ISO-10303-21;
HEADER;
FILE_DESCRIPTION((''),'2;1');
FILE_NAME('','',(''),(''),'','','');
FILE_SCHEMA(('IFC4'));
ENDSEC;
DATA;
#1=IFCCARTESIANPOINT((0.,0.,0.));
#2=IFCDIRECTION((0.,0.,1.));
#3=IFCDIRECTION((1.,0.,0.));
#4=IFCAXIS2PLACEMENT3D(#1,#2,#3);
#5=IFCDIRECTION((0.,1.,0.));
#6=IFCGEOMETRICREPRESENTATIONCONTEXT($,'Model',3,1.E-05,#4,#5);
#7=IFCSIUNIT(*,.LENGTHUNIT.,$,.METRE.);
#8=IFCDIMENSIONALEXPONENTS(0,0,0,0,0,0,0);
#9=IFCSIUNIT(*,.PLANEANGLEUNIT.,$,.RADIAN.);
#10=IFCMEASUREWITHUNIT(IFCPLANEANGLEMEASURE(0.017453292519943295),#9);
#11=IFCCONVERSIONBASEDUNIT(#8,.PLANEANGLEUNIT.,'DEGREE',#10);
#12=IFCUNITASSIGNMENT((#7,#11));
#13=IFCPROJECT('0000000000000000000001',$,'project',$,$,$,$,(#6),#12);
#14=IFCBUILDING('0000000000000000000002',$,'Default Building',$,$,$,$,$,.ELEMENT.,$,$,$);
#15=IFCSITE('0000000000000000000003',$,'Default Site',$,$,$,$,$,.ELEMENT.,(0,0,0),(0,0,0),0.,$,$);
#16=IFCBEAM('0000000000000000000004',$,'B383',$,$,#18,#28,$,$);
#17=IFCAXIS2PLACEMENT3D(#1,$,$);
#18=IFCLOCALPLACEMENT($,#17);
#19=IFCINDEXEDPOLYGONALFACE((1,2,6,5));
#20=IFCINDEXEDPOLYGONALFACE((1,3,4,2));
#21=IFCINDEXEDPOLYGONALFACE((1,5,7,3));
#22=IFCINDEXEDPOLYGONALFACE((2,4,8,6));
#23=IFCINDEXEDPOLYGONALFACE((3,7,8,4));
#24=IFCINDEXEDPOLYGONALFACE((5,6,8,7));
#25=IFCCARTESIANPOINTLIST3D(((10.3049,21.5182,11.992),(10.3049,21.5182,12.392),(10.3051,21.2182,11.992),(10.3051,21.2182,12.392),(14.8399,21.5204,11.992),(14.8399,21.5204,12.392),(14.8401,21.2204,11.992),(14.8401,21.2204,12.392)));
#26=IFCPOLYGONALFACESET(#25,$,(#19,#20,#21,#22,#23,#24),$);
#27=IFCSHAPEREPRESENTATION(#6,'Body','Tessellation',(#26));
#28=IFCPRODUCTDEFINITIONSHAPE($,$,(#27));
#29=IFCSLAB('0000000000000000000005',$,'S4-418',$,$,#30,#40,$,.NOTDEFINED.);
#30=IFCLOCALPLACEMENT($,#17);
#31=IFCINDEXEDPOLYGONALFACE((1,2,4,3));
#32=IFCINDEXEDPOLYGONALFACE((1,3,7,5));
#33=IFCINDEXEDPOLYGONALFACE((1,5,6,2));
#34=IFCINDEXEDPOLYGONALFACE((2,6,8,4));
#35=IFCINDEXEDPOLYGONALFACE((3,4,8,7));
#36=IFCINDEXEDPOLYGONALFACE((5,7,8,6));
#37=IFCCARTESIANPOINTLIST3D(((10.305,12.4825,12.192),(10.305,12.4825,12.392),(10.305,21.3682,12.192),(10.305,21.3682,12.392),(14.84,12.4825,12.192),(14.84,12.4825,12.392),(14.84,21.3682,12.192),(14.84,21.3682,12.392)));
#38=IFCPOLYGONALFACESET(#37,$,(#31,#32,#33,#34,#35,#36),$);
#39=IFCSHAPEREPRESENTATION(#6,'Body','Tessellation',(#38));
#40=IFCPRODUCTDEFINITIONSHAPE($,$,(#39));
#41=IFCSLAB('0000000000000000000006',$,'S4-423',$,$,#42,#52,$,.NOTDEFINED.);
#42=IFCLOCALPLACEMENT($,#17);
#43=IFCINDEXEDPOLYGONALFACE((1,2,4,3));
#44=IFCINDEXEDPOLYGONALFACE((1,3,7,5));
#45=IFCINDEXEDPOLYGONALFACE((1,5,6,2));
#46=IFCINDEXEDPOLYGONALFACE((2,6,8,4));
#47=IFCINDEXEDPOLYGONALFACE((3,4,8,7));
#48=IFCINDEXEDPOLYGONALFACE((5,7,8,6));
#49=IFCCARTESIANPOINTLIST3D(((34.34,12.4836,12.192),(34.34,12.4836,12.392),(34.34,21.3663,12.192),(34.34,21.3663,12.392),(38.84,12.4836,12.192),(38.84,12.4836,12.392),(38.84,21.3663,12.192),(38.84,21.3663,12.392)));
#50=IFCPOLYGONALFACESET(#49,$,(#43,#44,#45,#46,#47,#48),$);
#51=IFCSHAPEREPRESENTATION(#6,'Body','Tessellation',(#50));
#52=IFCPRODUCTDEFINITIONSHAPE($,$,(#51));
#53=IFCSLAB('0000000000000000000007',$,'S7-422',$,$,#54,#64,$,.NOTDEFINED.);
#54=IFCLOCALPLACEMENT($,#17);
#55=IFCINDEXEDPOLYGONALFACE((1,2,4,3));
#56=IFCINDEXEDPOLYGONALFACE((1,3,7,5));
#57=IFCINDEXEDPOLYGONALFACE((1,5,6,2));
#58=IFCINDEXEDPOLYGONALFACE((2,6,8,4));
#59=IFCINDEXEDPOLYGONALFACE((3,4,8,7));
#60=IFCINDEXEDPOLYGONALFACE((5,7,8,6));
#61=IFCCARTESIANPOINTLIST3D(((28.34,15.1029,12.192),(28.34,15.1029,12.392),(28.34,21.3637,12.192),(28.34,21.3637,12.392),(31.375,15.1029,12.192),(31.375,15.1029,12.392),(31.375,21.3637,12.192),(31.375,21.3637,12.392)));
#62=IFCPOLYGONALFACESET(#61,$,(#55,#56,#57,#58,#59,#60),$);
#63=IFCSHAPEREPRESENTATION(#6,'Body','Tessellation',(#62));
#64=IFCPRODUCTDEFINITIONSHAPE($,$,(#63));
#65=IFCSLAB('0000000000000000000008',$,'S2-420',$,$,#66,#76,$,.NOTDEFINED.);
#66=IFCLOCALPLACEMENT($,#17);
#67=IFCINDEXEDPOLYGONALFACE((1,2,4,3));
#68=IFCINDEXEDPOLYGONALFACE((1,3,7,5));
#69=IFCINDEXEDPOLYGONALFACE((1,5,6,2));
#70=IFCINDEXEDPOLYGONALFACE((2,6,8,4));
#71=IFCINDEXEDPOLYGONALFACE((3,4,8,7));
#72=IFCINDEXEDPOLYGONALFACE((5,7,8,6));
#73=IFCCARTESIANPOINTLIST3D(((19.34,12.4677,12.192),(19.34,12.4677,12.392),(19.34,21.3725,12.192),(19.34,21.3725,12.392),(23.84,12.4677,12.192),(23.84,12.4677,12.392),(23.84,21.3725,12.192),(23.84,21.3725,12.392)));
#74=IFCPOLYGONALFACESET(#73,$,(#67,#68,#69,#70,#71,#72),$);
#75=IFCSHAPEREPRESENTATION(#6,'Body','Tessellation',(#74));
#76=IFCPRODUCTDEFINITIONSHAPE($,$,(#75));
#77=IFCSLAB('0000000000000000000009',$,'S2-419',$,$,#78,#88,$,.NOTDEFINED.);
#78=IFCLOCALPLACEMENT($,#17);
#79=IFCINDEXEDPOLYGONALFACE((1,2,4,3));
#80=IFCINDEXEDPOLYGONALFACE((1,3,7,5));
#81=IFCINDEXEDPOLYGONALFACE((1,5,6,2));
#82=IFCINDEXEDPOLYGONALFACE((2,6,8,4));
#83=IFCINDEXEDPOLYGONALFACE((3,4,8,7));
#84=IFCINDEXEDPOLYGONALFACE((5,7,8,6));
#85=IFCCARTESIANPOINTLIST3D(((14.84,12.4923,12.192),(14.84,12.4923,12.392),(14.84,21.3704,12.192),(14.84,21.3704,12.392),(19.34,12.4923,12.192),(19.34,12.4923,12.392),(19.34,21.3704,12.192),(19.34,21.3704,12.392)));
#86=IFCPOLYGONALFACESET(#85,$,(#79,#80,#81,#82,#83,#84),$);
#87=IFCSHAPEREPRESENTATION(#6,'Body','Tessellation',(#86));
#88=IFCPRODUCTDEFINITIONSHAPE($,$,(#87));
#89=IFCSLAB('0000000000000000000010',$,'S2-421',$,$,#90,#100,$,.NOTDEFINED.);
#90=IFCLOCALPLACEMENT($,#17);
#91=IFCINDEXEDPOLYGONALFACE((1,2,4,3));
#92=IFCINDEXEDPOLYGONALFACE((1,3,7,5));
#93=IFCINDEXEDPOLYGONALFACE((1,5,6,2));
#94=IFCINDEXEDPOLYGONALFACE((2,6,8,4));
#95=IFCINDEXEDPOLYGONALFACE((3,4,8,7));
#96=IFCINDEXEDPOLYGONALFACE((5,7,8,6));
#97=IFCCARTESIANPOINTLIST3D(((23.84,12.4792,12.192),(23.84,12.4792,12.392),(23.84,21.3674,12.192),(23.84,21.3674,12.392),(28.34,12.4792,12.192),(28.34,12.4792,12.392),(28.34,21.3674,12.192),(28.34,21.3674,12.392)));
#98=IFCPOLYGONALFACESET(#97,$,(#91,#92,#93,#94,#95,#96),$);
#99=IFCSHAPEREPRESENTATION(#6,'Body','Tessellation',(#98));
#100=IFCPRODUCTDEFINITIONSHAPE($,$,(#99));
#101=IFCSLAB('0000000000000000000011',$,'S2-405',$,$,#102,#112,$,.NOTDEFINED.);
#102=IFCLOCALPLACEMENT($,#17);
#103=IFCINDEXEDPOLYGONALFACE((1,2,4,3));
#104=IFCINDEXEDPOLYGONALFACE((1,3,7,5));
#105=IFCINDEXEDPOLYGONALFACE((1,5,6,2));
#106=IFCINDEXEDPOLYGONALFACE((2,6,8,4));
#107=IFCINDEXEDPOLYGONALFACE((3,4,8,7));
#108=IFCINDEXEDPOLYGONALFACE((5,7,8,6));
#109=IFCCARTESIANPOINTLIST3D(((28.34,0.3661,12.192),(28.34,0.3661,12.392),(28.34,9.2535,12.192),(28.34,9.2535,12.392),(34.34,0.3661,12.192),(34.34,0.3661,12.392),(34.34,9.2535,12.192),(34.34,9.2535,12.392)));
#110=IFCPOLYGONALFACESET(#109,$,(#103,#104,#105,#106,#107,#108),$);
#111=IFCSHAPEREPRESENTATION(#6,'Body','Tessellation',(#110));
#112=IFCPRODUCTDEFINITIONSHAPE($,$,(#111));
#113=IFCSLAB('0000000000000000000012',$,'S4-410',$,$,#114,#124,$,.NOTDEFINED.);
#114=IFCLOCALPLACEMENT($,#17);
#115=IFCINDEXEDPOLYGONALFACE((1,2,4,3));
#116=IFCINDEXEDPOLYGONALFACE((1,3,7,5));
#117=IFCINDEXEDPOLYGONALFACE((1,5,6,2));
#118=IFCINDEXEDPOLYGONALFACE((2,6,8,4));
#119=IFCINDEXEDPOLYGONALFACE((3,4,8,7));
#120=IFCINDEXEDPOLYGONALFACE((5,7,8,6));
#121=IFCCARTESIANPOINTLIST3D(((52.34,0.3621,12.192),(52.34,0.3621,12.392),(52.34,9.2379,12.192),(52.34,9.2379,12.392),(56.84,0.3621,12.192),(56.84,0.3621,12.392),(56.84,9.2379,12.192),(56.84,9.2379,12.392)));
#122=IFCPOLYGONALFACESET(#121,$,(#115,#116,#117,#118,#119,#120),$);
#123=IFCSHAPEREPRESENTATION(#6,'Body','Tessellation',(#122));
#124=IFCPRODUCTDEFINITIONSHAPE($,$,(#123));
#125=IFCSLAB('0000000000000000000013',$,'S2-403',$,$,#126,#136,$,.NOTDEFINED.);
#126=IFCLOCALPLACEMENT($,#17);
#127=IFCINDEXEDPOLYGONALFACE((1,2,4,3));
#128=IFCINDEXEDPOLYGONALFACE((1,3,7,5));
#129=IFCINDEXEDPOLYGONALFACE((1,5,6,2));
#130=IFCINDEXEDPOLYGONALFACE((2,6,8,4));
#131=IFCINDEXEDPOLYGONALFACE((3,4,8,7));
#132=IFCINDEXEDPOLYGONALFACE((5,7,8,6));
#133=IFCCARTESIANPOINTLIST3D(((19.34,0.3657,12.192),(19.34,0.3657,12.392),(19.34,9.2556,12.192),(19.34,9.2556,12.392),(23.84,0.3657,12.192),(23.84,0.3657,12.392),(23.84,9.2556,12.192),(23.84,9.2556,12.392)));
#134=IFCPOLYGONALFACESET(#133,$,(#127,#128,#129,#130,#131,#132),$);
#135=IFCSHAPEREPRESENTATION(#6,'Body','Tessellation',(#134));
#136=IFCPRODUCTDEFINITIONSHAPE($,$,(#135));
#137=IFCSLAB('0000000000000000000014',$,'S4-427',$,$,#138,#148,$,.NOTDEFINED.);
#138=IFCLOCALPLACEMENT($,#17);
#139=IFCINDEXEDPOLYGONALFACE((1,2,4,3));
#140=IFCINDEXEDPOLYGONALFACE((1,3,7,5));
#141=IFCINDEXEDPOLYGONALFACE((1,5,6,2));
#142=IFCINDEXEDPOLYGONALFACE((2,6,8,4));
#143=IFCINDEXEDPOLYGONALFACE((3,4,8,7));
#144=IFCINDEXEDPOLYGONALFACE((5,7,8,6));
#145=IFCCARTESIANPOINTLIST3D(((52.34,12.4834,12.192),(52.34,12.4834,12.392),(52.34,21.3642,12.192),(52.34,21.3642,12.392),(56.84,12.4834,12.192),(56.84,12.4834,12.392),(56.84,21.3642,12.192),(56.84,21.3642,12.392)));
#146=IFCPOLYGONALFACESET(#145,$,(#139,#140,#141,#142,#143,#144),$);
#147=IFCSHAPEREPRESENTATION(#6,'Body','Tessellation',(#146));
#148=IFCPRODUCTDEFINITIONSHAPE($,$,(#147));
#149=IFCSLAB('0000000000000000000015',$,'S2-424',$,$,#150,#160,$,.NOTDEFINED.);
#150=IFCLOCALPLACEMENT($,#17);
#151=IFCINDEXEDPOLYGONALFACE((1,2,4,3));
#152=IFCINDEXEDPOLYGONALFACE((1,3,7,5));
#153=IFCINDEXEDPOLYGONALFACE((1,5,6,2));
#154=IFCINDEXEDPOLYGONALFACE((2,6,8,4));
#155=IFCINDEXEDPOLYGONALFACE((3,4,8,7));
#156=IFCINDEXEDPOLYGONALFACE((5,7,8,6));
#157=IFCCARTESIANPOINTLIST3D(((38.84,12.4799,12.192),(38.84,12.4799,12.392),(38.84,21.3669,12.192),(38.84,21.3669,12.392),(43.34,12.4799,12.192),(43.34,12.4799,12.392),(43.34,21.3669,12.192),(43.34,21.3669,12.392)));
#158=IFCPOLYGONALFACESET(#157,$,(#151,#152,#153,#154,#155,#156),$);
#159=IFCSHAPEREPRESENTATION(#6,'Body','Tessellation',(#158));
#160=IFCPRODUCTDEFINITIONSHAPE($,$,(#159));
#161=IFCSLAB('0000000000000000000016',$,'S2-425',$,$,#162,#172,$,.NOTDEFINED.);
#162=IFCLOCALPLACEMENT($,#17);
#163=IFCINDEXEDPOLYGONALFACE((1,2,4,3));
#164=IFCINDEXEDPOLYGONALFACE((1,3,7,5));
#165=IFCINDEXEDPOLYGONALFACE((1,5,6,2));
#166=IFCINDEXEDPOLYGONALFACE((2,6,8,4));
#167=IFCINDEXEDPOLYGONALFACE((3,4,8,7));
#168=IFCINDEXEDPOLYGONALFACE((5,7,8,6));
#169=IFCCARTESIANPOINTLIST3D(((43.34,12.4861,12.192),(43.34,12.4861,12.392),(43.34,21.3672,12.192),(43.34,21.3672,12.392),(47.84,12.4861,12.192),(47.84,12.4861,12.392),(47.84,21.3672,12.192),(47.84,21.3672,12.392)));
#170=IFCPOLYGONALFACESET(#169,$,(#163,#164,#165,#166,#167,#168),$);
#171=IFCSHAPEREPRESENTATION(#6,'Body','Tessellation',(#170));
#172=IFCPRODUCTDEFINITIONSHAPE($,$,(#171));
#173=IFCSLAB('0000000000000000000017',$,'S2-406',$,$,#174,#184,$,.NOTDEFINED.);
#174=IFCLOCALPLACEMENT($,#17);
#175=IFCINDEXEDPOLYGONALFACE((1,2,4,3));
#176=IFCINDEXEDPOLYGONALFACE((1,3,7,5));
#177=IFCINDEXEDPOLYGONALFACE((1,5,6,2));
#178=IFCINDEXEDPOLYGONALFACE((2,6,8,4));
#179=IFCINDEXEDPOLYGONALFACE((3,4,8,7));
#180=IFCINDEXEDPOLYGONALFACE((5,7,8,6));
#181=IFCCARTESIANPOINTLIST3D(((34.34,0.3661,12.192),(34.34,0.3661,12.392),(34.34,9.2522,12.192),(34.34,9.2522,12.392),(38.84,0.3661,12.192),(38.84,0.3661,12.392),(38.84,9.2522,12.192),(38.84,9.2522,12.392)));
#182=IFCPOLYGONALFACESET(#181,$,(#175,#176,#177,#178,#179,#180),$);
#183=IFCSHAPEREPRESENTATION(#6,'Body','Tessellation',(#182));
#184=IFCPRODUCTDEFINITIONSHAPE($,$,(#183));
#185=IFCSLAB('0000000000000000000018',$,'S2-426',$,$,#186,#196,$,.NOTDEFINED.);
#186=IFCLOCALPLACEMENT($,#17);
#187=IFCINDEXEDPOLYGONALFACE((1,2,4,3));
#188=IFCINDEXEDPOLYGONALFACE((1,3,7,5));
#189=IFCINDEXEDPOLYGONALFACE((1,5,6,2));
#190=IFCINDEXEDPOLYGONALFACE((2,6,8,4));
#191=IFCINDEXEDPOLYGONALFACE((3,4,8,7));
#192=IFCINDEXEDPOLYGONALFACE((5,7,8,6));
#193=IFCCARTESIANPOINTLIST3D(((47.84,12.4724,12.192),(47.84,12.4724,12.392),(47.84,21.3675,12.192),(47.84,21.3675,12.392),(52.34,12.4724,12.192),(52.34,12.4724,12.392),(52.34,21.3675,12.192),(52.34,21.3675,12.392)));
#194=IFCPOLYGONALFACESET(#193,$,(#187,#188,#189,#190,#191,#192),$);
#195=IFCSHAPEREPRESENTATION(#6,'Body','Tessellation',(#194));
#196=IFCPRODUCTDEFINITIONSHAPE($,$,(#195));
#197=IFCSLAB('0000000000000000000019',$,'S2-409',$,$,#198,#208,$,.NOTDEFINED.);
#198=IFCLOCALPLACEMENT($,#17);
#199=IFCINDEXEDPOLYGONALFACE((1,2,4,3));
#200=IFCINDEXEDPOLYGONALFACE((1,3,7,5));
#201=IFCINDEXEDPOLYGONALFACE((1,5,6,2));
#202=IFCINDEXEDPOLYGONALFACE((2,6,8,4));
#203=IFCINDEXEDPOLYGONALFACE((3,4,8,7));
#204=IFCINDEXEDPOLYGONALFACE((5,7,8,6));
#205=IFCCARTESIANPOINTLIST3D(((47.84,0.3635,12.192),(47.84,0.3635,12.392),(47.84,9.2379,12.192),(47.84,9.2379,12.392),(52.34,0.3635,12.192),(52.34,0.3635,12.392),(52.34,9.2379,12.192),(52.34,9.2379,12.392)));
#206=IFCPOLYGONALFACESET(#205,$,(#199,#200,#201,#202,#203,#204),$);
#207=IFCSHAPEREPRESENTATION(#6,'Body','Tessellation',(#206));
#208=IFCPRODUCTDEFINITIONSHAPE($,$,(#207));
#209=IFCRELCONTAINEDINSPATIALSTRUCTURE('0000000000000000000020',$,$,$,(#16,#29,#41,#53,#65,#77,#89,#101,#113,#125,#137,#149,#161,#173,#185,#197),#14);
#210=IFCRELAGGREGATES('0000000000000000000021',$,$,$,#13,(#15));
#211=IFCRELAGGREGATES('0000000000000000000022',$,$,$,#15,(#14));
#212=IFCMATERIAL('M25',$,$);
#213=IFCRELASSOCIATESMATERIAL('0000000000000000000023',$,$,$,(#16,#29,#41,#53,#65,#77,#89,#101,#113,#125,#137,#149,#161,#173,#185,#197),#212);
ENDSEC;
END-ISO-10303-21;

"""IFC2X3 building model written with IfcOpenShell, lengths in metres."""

from ifc_helpers import new_model, entity, si_unit, converted_unit, direction, frame, frame_2d, origin_with_axes, place, context, project, spatial, rectangle, extrude, material, element, save


model = new_model("IFC2X3")

# Units and contexts
model_context = context("Model", 3, precision=1e-05, world=origin_with_axes(), true_north=direction((0.0, 1.0, 0.0)))
ifc_project = project(units=[si_unit("LENGTHUNIT", "METRE"), converted_unit("PLANEANGLEUNIT", "DEGREE", entity("IfcPlaneAngleMeasure", 0.017453292519943295), si_unit("PLANEANGLEUNIT", "RADIAN"), dimensions=[0, 0, 0, 0, 0, 0, 0])], contexts=[model_context])

# Site, building
site = spatial("IfcSite", under=ifc_project, Name="Default Site", CompositionType="ELEMENT", RefLatitude=(0, 0, 0), RefLongitude=(0, 0, 0), RefElevation=0.0)
building = spatial("IfcBuilding", under=site, Name="Default Building", CompositionType="ELEMENT")

# Beam
ifc_material = material(Name="M25")
placement = place(None, origin_with_axes())
element("IfcBeam", 1, at=placement, inside=building, material=ifc_material, Name="B383", context=model_context, shape_type="SweptSolid", body=[
    extrude(rectangle(XDim=0.3, YDim=0.4, at=frame_2d((0.0, 0.0), x_axis=(0.0, 1.0, 0.0))), frame((10.305, 21.3682, 12.192), z_axis=(1.0, 0.000476, 0.0), x_axis=(0.0, 0.0, -1.0)), (0.0, 0.0, 1.0), 4.535),
])

# Slabs
element("IfcSlab", 2, at=placement, inside=building, material=ifc_material, Name="S4-418", PredefinedType="NOTDEFINED", context=model_context, shape_type="SweptSolid", body=[
    extrude(rectangle(XDim=4.535, YDim=8.8857, at=frame_2d((0.0, 0.0), x_axis=(1.0, 0.0, 0.0))), frame((12.5725, 16.9253, 12.192), z_axis=(0.0, 0.0, 1.0), x_axis=(1.0, 0.0, 0.0)), (0.0, 0.0, 1.0), 0.2),
])
element("IfcSlab", 3, at=placement, inside=building, material=ifc_material, Name="S4-423", PredefinedType="NOTDEFINED", context=model_context, shape_type="SweptSolid", body=[
    extrude(rectangle(XDim=4.5, YDim=8.8827, at=frame_2d((0.0, 0.0), x_axis=(1.0, 0.0, 0.0))), frame((36.59, 16.925, 12.192), z_axis=(0.0, 0.0, 1.0), x_axis=(1.0, 0.0, 0.0)), (0.0, 0.0, 1.0), 0.2),
])
element("IfcSlab", 4, at=placement, inside=building, material=ifc_material, Name="S7-422", PredefinedType="NOTDEFINED", context=model_context, shape_type="SweptSolid", body=[
    extrude(rectangle(XDim=3.035, YDim=6.2608, at=frame_2d((0.0, 0.0), x_axis=(1.0, 0.0, 0.0))), frame((29.8575, 18.2333, 12.192), z_axis=(0.0, 0.0, 1.0), x_axis=(1.0, 0.0, 0.0)), (0.0, 0.0, 1.0), 0.2),
])
element("IfcSlab", 5, at=placement, inside=building, material=ifc_material, Name="S2-420", PredefinedType="NOTDEFINED", context=model_context, shape_type="SweptSolid", body=[
    extrude(rectangle(XDim=4.5, YDim=8.9048, at=frame_2d((0.0, 0.0), x_axis=(1.0, 0.0, 0.0))), frame((21.59, 16.9201, 12.192), z_axis=(0.0, 0.0, 1.0), x_axis=(1.0, 0.0, 0.0)), (0.0, 0.0, 1.0), 0.2),
])
element("IfcSlab", 6, at=placement, inside=building, material=ifc_material, Name="S2-419", PredefinedType="NOTDEFINED", context=model_context, shape_type="SweptSolid", body=[
    extrude(rectangle(XDim=4.5, YDim=8.8781, at=frame_2d((0.0, 0.0), x_axis=(1.0, 0.0, 0.0))), frame((17.09, 16.9313, 12.192), z_axis=(0.0, 0.0, 1.0), x_axis=(1.0, 0.0, 0.0)), (0.0, 0.0, 1.0), 0.2),
])
element("IfcSlab", 7, at=placement, inside=building, material=ifc_material, Name="S2-421", PredefinedType="NOTDEFINED", context=model_context, shape_type="SweptSolid", body=[
    extrude(rectangle(XDim=4.5, YDim=8.8882, at=frame_2d((0.0, 0.0), x_axis=(1.0, 0.0, 0.0))), frame((26.09, 16.9233, 12.192), z_axis=(0.0, 0.0, 1.0), x_axis=(1.0, 0.0, 0.0)), (0.0, 0.0, 1.0), 0.2),
])
element("IfcSlab", 8, at=placement, inside=building, material=ifc_material, Name="S2-405", PredefinedType="NOTDEFINED", context=model_context, shape_type="SweptSolid", body=[
    extrude(rectangle(XDim=6.0, YDim=8.8874, at=frame_2d((0.0, 0.0), x_axis=(1.0, 0.0, 0.0))), frame((31.34, 4.8098, 12.192), z_axis=(0.0, 0.0, 1.0), x_axis=(1.0, 0.0, 0.0)), (0.0, 0.0, 1.0), 0.2),
])
element("IfcSlab", 9, at=placement, inside=building, material=ifc_material, Name="S4-410", PredefinedType="NOTDEFINED", context=model_context, shape_type="SweptSolid", body=[
    extrude(rectangle(XDim=4.5, YDim=8.8758, at=frame_2d((0.0, 0.0), x_axis=(1.0, 0.0, 0.0))), frame((54.59, 4.8, 12.192), z_axis=(0.0, 0.0, 1.0), x_axis=(1.0, 0.0, 0.0)), (0.0, 0.0, 1.0), 0.2),
])
element("IfcSlab", 10, at=placement, inside=building, material=ifc_material, Name="S2-403", PredefinedType="NOTDEFINED", context=model_context, shape_type="SweptSolid", body=[
    extrude(rectangle(XDim=4.5, YDim=8.89, at=frame_2d((0.0, 0.0), x_axis=(1.0, 0.0, 0.0))), frame((21.59, 4.8106, 12.192), z_axis=(0.0, 0.0, 1.0), x_axis=(1.0, 0.0, 0.0)), (0.0, 0.0, 1.0), 0.2),
])
element("IfcSlab", 11, at=placement, inside=building, material=ifc_material, Name="S4-427", PredefinedType="NOTDEFINED", context=model_context, shape_type="SweptSolid", body=[
    extrude(rectangle(XDim=4.5, YDim=8.8807, at=frame_2d((0.0, 0.0), x_axis=(1.0, 0.0, 0.0))), frame((54.59, 16.9238, 12.192), z_axis=(0.0, 0.0, 1.0), x_axis=(1.0, 0.0, 0.0)), (0.0, 0.0, 1.0), 0.2),
])
element("IfcSlab", 12, at=placement, inside=building, material=ifc_material, Name="S2-424", PredefinedType="NOTDEFINED", context=model_context, shape_type="SweptSolid", body=[
    extrude(rectangle(XDim=4.5, YDim=8.8871, at=frame_2d((0.0, 0.0), x_axis=(1.0, 0.0, 0.0))), frame((41.09, 16.9234, 12.192), z_axis=(0.0, 0.0, 1.0), x_axis=(1.0, 0.0, 0.0)), (0.0, 0.0, 1.0), 0.2),
])
element("IfcSlab", 13, at=placement, inside=building, material=ifc_material, Name="S2-425", PredefinedType="NOTDEFINED", context=model_context, shape_type="SweptSolid", body=[
    extrude(rectangle(XDim=4.5, YDim=8.8811, at=frame_2d((0.0, 0.0), x_axis=(1.0, 0.0, 0.0))), frame((45.59, 16.9266, 12.192), z_axis=(0.0, 0.0, 1.0), x_axis=(1.0, 0.0, 0.0)), (0.0, 0.0, 1.0), 0.2),
])
element("IfcSlab", 14, at=placement, inside=building, material=ifc_material, Name="S2-406", PredefinedType="NOTDEFINED", context=model_context, shape_type="SweptSolid", body=[
    extrude(rectangle(XDim=4.5, YDim=8.8861, at=frame_2d((0.0, 0.0), x_axis=(1.0, 0.0, 0.0))), frame((36.59, 4.8092, 12.192), z_axis=(0.0, 0.0, 1.0), x_axis=(1.0, 0.0, 0.0)), (0.0, 0.0, 1.0), 0.2),
])
element("IfcSlab", 15, at=placement, inside=building, material=ifc_material, Name="S2-426", PredefinedType="NOTDEFINED", context=model_context, shape_type="SweptSolid", body=[
    extrude(rectangle(XDim=4.5, YDim=8.8951, at=frame_2d((0.0, 0.0), x_axis=(1.0, 0.0, 0.0))), frame((50.09, 16.9199, 12.192), z_axis=(0.0, 0.0, 1.0), x_axis=(1.0, 0.0, 0.0)), (0.0, 0.0, 1.0), 0.2),
])
element("IfcSlab", 16, at=placement, inside=building, material=ifc_material, Name="S2-409", PredefinedType="NOTDEFINED", context=model_context, shape_type="SweptSolid", body=[
    extrude(rectangle(XDim=4.5, YDim=8.8744, at=frame_2d((0.0, 0.0), x_axis=(1.0, 0.0, 0.0))), frame((50.09, 4.8007, 12.192), z_axis=(0.0, 0.0, 1.0), x_axis=(1.0, 0.0, 0.0)), (0.0, 0.0, 1.0), 0.2),
])

save(model, "model.ifc")
